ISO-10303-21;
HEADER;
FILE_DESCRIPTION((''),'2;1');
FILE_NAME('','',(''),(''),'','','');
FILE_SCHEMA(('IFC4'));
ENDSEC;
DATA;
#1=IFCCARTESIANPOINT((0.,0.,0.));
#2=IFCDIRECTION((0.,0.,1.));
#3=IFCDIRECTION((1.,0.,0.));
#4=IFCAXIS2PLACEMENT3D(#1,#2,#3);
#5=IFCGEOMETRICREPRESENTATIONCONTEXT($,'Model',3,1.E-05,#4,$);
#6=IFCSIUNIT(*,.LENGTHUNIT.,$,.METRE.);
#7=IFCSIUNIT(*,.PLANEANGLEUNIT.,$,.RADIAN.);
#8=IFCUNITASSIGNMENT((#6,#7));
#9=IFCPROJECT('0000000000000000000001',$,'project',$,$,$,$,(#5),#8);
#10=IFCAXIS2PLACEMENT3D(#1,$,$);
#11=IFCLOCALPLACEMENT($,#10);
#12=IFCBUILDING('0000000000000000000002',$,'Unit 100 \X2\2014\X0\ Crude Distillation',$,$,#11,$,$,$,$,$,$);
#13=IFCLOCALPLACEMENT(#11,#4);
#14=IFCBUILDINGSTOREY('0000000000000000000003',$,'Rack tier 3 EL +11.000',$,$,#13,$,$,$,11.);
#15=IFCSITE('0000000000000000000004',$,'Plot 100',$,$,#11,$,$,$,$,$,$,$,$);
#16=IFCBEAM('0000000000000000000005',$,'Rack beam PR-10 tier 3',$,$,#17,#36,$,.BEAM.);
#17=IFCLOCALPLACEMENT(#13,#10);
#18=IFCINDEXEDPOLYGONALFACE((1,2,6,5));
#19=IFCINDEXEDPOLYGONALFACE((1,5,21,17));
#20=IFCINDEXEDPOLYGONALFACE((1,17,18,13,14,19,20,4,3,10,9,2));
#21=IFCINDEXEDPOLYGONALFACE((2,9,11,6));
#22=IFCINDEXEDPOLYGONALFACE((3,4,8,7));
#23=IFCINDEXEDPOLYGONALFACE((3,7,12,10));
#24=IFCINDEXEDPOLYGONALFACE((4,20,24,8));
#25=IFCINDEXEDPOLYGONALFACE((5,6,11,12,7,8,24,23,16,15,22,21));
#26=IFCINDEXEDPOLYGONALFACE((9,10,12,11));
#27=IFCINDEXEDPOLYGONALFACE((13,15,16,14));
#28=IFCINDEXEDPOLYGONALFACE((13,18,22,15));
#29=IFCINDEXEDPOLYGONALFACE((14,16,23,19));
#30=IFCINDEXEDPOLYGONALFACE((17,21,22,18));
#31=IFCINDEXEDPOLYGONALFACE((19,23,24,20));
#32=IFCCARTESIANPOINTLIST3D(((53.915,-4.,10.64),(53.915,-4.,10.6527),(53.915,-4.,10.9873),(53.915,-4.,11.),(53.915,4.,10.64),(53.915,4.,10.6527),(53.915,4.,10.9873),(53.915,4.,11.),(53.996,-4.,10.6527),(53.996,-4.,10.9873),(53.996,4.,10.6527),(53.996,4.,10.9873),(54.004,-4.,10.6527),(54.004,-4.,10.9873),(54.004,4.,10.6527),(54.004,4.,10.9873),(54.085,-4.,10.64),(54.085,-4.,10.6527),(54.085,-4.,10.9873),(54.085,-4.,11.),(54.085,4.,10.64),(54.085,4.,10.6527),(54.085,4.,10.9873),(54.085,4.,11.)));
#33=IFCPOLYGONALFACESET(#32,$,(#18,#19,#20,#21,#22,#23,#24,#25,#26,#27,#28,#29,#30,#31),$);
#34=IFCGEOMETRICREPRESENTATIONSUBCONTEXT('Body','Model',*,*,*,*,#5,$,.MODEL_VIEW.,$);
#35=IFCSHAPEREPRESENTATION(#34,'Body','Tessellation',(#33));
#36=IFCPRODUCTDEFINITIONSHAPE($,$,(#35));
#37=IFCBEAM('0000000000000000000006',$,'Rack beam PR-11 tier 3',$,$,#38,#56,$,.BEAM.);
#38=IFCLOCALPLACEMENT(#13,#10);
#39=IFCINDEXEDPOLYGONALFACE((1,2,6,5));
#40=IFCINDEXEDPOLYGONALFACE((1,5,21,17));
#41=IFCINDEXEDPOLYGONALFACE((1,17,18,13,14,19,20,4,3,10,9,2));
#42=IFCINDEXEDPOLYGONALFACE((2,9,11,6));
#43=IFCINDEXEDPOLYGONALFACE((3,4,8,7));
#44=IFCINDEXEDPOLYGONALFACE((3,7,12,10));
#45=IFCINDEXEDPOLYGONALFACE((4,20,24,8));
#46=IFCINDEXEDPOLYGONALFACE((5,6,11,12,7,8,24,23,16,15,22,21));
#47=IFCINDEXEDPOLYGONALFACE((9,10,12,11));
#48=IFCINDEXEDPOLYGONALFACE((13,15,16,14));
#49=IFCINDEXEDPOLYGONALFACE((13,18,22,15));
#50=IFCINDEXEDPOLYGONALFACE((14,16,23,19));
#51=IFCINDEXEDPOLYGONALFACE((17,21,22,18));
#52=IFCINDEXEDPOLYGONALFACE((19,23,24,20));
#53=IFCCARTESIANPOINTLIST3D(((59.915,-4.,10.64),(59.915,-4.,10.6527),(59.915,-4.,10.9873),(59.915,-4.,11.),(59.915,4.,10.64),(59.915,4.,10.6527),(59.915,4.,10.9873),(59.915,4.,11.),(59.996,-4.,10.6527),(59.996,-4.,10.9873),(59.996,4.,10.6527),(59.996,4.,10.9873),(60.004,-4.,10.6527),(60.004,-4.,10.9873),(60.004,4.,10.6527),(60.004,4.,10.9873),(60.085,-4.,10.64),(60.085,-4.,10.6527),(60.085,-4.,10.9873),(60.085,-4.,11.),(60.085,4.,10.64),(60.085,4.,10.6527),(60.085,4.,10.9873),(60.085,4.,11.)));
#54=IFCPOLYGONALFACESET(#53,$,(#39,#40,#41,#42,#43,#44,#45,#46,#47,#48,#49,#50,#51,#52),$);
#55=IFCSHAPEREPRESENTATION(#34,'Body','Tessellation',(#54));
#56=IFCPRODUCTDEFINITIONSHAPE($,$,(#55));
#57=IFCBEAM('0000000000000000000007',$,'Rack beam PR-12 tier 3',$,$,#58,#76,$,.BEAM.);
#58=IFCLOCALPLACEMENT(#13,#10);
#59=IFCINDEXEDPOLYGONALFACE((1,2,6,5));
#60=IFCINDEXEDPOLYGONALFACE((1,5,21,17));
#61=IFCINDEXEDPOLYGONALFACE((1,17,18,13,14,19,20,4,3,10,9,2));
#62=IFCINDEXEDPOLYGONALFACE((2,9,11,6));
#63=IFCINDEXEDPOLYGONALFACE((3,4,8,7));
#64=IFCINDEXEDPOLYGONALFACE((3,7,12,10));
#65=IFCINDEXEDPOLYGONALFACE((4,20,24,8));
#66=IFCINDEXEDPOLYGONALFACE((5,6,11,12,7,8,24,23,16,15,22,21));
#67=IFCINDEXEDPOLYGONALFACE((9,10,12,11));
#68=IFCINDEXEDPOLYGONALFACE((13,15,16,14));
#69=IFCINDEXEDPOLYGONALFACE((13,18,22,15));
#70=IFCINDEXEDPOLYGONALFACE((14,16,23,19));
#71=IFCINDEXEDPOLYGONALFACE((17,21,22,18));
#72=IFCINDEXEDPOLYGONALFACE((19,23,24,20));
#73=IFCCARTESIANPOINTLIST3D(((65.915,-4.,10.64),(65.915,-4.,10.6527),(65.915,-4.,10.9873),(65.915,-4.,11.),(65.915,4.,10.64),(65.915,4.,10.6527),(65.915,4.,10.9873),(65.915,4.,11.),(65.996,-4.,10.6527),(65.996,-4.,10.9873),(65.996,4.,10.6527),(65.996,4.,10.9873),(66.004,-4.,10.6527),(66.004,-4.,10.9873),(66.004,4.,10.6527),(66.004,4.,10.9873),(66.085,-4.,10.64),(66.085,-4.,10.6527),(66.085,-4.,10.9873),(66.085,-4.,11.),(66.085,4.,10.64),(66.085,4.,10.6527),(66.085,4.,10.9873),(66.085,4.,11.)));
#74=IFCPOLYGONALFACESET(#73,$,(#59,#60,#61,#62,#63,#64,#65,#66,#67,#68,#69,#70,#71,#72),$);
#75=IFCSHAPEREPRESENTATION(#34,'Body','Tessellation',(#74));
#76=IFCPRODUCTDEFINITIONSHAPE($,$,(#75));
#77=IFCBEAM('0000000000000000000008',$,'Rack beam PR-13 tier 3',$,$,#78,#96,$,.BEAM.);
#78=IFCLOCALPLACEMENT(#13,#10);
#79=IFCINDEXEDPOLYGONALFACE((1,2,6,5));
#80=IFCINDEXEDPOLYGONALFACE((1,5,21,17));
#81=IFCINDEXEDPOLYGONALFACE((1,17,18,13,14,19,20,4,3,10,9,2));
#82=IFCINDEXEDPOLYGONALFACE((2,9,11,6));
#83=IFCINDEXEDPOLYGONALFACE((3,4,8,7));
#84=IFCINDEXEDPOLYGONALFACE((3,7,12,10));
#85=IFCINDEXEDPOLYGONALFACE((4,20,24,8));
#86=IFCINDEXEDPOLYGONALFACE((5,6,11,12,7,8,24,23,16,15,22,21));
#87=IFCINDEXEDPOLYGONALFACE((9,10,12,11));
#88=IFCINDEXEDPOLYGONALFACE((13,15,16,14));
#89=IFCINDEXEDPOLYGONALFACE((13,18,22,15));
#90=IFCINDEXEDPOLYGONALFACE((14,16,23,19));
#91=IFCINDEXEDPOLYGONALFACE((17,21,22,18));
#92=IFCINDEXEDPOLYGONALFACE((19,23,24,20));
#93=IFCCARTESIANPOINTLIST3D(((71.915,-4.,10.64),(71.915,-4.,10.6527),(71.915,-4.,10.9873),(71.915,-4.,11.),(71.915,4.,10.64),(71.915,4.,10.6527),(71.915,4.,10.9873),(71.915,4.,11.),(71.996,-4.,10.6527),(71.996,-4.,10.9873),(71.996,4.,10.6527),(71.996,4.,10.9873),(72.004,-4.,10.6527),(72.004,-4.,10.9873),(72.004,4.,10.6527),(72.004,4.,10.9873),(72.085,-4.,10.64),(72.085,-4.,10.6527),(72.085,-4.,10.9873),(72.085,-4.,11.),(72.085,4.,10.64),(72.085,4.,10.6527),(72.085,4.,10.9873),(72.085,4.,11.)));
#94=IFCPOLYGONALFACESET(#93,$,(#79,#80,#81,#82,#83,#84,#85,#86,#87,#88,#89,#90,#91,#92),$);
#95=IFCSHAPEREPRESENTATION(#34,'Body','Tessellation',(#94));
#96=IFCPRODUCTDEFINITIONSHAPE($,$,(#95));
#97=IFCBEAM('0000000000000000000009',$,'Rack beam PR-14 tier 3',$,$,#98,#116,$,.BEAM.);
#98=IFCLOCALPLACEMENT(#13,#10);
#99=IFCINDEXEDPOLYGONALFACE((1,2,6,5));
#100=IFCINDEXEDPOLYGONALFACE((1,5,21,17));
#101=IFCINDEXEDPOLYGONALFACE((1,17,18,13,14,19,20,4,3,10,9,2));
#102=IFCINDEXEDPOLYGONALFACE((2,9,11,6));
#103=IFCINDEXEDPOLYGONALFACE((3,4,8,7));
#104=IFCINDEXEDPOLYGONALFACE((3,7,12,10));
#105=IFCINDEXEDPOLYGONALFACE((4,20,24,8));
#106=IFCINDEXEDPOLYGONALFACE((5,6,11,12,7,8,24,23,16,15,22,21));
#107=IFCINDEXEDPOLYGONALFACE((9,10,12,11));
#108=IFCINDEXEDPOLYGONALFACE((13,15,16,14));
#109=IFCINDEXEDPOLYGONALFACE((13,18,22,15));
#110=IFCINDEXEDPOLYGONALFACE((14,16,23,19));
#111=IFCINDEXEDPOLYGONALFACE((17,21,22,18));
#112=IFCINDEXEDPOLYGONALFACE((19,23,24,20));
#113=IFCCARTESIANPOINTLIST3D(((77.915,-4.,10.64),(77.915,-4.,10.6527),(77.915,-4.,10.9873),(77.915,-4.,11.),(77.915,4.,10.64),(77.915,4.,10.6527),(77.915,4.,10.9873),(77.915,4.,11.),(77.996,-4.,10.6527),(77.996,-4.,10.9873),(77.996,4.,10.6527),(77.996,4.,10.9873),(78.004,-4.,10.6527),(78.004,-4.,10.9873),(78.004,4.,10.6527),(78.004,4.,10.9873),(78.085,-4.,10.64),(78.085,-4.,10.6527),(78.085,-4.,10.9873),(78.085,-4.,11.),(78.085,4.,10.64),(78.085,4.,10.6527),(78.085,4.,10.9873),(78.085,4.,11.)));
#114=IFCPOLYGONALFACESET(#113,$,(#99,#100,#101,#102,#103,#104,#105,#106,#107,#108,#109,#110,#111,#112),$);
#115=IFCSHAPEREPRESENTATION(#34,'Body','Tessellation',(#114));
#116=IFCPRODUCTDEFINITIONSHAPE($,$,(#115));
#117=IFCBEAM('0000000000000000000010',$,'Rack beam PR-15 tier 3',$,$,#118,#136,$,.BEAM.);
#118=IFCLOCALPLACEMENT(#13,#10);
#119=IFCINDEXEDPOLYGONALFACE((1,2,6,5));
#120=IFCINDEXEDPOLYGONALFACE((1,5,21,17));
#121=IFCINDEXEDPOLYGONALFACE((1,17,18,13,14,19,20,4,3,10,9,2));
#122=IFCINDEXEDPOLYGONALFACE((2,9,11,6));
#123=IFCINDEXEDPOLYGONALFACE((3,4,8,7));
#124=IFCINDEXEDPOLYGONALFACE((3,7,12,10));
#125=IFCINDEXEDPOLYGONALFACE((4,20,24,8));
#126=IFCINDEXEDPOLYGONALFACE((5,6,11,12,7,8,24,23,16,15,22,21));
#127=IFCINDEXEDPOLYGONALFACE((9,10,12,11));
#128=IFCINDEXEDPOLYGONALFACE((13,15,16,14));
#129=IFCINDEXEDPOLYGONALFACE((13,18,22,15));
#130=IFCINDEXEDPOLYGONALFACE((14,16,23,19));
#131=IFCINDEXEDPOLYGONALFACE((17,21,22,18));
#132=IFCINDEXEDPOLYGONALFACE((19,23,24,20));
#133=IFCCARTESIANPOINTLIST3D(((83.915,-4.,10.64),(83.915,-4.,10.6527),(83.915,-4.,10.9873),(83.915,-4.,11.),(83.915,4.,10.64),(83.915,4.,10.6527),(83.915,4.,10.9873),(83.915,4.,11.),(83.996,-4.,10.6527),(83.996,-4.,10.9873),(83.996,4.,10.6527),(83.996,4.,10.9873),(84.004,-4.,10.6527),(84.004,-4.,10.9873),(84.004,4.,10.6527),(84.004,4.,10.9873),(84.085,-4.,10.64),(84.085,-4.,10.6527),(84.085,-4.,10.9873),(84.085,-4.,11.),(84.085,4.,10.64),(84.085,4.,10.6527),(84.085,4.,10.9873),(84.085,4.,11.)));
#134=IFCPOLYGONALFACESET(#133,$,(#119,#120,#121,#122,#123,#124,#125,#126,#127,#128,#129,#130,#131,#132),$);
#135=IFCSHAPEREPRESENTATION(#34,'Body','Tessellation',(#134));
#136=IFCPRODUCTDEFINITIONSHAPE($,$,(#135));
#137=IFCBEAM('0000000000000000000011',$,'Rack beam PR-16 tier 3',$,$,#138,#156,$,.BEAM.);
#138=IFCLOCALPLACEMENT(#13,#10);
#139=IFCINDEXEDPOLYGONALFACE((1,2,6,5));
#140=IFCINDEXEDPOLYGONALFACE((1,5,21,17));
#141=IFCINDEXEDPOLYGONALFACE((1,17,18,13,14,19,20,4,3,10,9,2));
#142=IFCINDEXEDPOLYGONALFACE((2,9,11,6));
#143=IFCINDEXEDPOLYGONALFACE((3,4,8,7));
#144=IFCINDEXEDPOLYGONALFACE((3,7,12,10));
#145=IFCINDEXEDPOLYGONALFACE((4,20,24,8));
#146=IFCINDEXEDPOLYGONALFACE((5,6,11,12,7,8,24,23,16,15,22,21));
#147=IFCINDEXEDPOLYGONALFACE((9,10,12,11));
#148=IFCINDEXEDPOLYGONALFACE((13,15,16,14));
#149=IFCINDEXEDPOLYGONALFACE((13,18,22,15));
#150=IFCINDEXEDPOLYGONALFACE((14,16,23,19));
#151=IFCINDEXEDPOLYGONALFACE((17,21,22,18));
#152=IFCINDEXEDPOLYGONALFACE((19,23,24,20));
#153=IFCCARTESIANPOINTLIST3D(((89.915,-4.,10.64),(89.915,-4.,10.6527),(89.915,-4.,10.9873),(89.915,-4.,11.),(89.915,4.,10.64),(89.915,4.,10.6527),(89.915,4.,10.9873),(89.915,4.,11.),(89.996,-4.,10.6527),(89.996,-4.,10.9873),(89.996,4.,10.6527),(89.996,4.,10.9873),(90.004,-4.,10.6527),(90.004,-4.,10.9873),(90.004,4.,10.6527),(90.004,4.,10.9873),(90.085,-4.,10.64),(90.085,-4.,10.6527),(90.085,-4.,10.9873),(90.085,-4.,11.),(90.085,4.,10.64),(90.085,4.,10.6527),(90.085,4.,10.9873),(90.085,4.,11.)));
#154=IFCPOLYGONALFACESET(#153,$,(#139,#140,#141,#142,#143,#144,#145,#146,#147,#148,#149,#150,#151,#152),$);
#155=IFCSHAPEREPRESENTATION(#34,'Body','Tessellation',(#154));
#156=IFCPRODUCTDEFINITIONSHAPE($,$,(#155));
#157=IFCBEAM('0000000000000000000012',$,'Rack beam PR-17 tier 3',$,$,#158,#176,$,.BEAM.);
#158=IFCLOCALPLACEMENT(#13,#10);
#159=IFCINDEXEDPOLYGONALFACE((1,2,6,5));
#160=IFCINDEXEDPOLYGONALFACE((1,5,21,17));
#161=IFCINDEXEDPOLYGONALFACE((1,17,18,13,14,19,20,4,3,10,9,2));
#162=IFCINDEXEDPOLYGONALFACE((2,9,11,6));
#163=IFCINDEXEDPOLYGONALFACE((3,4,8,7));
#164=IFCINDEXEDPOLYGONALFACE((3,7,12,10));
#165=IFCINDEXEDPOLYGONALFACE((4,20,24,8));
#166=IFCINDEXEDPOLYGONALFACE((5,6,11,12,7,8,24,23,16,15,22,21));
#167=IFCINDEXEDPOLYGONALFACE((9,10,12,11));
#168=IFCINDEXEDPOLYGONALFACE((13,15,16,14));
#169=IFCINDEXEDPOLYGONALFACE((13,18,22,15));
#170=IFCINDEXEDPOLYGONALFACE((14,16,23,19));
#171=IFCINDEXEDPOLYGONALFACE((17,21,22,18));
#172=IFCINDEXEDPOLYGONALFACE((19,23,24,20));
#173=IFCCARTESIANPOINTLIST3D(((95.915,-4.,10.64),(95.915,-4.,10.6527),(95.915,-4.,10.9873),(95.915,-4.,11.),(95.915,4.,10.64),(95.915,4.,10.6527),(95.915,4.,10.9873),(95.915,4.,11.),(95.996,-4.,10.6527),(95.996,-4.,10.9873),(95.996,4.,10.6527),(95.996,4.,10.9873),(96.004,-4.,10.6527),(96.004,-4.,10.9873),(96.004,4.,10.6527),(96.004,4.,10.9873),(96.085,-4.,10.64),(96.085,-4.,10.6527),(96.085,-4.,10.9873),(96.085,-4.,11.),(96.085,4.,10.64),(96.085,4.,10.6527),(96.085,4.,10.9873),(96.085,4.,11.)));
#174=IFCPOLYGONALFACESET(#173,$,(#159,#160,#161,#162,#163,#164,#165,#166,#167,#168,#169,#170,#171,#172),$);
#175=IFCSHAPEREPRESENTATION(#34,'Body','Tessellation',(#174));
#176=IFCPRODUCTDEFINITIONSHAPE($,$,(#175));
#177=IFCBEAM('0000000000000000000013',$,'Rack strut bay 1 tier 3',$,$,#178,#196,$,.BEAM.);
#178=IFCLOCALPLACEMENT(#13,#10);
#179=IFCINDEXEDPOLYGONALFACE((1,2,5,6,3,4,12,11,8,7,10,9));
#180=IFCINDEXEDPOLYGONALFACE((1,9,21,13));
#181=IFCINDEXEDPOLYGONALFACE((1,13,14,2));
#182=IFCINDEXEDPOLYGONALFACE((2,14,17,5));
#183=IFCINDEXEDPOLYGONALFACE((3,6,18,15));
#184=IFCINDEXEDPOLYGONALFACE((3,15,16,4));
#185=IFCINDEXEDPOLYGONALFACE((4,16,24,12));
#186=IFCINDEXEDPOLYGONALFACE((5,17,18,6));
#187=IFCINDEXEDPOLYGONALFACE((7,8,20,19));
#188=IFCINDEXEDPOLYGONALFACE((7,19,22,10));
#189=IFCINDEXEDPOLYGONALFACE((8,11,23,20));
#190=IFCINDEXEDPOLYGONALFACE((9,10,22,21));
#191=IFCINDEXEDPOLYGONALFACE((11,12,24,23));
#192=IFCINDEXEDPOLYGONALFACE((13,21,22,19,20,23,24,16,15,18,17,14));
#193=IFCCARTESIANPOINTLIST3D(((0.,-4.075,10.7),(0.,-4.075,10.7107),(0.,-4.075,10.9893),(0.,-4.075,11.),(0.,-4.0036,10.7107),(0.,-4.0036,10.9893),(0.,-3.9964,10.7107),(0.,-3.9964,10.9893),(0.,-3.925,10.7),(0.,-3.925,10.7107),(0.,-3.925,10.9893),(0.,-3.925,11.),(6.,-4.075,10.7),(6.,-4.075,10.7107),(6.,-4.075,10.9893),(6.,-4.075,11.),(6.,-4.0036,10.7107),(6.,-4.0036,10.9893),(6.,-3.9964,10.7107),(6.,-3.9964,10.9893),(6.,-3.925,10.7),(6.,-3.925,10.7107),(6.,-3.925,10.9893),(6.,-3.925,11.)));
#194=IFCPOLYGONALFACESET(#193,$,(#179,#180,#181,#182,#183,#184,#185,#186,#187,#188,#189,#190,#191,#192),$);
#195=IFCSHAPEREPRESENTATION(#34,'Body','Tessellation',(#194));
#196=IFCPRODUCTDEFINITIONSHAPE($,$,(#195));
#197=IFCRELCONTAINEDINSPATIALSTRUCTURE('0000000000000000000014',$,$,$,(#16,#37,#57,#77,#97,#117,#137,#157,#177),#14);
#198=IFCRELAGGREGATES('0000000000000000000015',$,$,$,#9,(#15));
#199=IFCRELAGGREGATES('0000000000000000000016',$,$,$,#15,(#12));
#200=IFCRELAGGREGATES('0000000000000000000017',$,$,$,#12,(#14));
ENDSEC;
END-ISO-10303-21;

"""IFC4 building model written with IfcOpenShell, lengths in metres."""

from ifc_helpers import new_model, si_unit, frame, origin, origin_with_axes, origin_2d, place, context, subcontext, project, spatial, i_section, extrude, element, save


model = new_model("IFC4")

# Units and contexts
model_context = context("Model", 3, precision=1e-05, world=origin_with_axes())
body_context = subcontext(model_context, "Body", "Model", "MODEL_VIEW")
ifc_project = project(units=[si_unit("LENGTHUNIT", "METRE"), si_unit("PLANEANGLEUNIT", "RADIAN")], contexts=[model_context])

# Site, building, storey
placement = place(None, origin())
site = spatial("IfcSite", under=ifc_project, at=placement, Name="Plot 100")
building = spatial("IfcBuilding", under=site, at=placement, Name="Unit 100 — Crude Distillation")
storey_placement = place(placement, origin_with_axes())
storey = spatial("IfcBuildingStorey", under=building, at=storey_placement, Name="Rack tier 3 EL +11.000", Elevation=11.0)

# Beams
beam_1_placement = place(storey_placement, origin_with_axes())
element("IfcBeam", 1, at=beam_1_placement, inside=storey, Name="Rack beam PR-10 tier 3", PredefinedType="BEAM", context=body_context, shape_type="SweptSolid", body=[
    extrude(i_section(OverallWidth=0.17, OverallDepth=0.36, WebThickness=0.008, FlangeThickness=0.0127, at=origin_2d()), frame((54.0, -4.0, 10.82), z_axis=(0.0, 1.0, 0.0), x_axis=(-1.0, 0.0, 0.0)), (0.0, 0.0, 1.0), 8.0),
])
beam_2_placement = place(storey_placement, origin_with_axes())
element("IfcBeam", 2, at=beam_2_placement, inside=storey, Name="Rack beam PR-11 tier 3", PredefinedType="BEAM", context=body_context, shape_type="SweptSolid", body=[
    extrude(i_section(OverallWidth=0.17, OverallDepth=0.36, WebThickness=0.008, FlangeThickness=0.0127, at=origin_2d()), frame((60.0, -4.0, 10.82), z_axis=(0.0, 1.0, 0.0), x_axis=(-1.0, 0.0, 0.0)), (0.0, 0.0, 1.0), 8.0),
])
beam_3_placement = place(storey_placement, origin_with_axes())
element("IfcBeam", 3, at=beam_3_placement, inside=storey, Name="Rack beam PR-12 tier 3", PredefinedType="BEAM", context=body_context, shape_type="SweptSolid", body=[
    extrude(i_section(OverallWidth=0.17, OverallDepth=0.36, WebThickness=0.008, FlangeThickness=0.0127, at=origin_2d()), frame((66.0, -4.0, 10.82), z_axis=(0.0, 1.0, 0.0), x_axis=(-1.0, 0.0, 0.0)), (0.0, 0.0, 1.0), 8.0),
])
beam_4_placement = place(storey_placement, origin_with_axes())
element("IfcBeam", 4, at=beam_4_placement, inside=storey, Name="Rack beam PR-13 tier 3", PredefinedType="BEAM", context=body_context, shape_type="SweptSolid", body=[
    extrude(i_section(OverallWidth=0.17, OverallDepth=0.36, WebThickness=0.008, FlangeThickness=0.0127, at=origin_2d()), frame((72.0, -4.0, 10.82), z_axis=(0.0, 1.0, 0.0), x_axis=(-1.0, 0.0, 0.0)), (0.0, 0.0, 1.0), 8.0),
])
beam_5_placement = place(storey_placement, origin_with_axes())
element("IfcBeam", 5, at=beam_5_placement, inside=storey, Name="Rack beam PR-14 tier 3", PredefinedType="BEAM", context=body_context, shape_type="SweptSolid", body=[
    extrude(i_section(OverallWidth=0.17, OverallDepth=0.36, WebThickness=0.008, FlangeThickness=0.0127, at=origin_2d()), frame((78.0, -4.0, 10.82), z_axis=(0.0, 1.0, 0.0), x_axis=(-1.0, 0.0, 0.0)), (0.0, 0.0, 1.0), 8.0),
])
beam_6_placement = place(storey_placement, origin_with_axes())
element("IfcBeam", 6, at=beam_6_placement, inside=storey, Name="Rack beam PR-15 tier 3", PredefinedType="BEAM", context=body_context, shape_type="SweptSolid", body=[
    extrude(i_section(OverallWidth=0.17, OverallDepth=0.36, WebThickness=0.008, FlangeThickness=0.0127, at=origin_2d()), frame((84.0, -4.0, 10.82), z_axis=(0.0, 1.0, 0.0), x_axis=(-1.0, 0.0, 0.0)), (0.0, 0.0, 1.0), 8.0),
])
beam_7_placement = place(storey_placement, origin_with_axes())
element("IfcBeam", 7, at=beam_7_placement, inside=storey, Name="Rack beam PR-16 tier 3", PredefinedType="BEAM", context=body_context, shape_type="SweptSolid", body=[
    extrude(i_section(OverallWidth=0.17, OverallDepth=0.36, WebThickness=0.008, FlangeThickness=0.0127, at=origin_2d()), frame((90.0, -4.0, 10.82), z_axis=(0.0, 1.0, 0.0), x_axis=(-1.0, 0.0, 0.0)), (0.0, 0.0, 1.0), 8.0),
])
beam_8_placement = place(storey_placement, origin_with_axes())
element("IfcBeam", 8, at=beam_8_placement, inside=storey, Name="Rack beam PR-17 tier 3", PredefinedType="BEAM", context=body_context, shape_type="SweptSolid", body=[
    extrude(i_section(OverallWidth=0.17, OverallDepth=0.36, WebThickness=0.008, FlangeThickness=0.0127, at=origin_2d()), frame((96.0, -4.0, 10.82), z_axis=(0.0, 1.0, 0.0), x_axis=(-1.0, 0.0, 0.0)), (0.0, 0.0, 1.0), 8.0),
])
beam_9_placement = place(storey_placement, origin_with_axes())
element("IfcBeam", 9, at=beam_9_placement, inside=storey, Name="Rack strut bay 1 tier 3", PredefinedType="BEAM", context=body_context, shape_type="SweptSolid", body=[
    extrude(i_section(OverallWidth=0.15, OverallDepth=0.3, WebThickness=0.0071, FlangeThickness=0.0107, at=origin_2d()), frame((0.0, -4.0, 10.85), z_axis=(1.0, 0.0, 0.0), x_axis=(0.0, 1.0, 0.0)), (0.0, 0.0, 1.0), 6.0),
])

save(model, "model.ifc")
